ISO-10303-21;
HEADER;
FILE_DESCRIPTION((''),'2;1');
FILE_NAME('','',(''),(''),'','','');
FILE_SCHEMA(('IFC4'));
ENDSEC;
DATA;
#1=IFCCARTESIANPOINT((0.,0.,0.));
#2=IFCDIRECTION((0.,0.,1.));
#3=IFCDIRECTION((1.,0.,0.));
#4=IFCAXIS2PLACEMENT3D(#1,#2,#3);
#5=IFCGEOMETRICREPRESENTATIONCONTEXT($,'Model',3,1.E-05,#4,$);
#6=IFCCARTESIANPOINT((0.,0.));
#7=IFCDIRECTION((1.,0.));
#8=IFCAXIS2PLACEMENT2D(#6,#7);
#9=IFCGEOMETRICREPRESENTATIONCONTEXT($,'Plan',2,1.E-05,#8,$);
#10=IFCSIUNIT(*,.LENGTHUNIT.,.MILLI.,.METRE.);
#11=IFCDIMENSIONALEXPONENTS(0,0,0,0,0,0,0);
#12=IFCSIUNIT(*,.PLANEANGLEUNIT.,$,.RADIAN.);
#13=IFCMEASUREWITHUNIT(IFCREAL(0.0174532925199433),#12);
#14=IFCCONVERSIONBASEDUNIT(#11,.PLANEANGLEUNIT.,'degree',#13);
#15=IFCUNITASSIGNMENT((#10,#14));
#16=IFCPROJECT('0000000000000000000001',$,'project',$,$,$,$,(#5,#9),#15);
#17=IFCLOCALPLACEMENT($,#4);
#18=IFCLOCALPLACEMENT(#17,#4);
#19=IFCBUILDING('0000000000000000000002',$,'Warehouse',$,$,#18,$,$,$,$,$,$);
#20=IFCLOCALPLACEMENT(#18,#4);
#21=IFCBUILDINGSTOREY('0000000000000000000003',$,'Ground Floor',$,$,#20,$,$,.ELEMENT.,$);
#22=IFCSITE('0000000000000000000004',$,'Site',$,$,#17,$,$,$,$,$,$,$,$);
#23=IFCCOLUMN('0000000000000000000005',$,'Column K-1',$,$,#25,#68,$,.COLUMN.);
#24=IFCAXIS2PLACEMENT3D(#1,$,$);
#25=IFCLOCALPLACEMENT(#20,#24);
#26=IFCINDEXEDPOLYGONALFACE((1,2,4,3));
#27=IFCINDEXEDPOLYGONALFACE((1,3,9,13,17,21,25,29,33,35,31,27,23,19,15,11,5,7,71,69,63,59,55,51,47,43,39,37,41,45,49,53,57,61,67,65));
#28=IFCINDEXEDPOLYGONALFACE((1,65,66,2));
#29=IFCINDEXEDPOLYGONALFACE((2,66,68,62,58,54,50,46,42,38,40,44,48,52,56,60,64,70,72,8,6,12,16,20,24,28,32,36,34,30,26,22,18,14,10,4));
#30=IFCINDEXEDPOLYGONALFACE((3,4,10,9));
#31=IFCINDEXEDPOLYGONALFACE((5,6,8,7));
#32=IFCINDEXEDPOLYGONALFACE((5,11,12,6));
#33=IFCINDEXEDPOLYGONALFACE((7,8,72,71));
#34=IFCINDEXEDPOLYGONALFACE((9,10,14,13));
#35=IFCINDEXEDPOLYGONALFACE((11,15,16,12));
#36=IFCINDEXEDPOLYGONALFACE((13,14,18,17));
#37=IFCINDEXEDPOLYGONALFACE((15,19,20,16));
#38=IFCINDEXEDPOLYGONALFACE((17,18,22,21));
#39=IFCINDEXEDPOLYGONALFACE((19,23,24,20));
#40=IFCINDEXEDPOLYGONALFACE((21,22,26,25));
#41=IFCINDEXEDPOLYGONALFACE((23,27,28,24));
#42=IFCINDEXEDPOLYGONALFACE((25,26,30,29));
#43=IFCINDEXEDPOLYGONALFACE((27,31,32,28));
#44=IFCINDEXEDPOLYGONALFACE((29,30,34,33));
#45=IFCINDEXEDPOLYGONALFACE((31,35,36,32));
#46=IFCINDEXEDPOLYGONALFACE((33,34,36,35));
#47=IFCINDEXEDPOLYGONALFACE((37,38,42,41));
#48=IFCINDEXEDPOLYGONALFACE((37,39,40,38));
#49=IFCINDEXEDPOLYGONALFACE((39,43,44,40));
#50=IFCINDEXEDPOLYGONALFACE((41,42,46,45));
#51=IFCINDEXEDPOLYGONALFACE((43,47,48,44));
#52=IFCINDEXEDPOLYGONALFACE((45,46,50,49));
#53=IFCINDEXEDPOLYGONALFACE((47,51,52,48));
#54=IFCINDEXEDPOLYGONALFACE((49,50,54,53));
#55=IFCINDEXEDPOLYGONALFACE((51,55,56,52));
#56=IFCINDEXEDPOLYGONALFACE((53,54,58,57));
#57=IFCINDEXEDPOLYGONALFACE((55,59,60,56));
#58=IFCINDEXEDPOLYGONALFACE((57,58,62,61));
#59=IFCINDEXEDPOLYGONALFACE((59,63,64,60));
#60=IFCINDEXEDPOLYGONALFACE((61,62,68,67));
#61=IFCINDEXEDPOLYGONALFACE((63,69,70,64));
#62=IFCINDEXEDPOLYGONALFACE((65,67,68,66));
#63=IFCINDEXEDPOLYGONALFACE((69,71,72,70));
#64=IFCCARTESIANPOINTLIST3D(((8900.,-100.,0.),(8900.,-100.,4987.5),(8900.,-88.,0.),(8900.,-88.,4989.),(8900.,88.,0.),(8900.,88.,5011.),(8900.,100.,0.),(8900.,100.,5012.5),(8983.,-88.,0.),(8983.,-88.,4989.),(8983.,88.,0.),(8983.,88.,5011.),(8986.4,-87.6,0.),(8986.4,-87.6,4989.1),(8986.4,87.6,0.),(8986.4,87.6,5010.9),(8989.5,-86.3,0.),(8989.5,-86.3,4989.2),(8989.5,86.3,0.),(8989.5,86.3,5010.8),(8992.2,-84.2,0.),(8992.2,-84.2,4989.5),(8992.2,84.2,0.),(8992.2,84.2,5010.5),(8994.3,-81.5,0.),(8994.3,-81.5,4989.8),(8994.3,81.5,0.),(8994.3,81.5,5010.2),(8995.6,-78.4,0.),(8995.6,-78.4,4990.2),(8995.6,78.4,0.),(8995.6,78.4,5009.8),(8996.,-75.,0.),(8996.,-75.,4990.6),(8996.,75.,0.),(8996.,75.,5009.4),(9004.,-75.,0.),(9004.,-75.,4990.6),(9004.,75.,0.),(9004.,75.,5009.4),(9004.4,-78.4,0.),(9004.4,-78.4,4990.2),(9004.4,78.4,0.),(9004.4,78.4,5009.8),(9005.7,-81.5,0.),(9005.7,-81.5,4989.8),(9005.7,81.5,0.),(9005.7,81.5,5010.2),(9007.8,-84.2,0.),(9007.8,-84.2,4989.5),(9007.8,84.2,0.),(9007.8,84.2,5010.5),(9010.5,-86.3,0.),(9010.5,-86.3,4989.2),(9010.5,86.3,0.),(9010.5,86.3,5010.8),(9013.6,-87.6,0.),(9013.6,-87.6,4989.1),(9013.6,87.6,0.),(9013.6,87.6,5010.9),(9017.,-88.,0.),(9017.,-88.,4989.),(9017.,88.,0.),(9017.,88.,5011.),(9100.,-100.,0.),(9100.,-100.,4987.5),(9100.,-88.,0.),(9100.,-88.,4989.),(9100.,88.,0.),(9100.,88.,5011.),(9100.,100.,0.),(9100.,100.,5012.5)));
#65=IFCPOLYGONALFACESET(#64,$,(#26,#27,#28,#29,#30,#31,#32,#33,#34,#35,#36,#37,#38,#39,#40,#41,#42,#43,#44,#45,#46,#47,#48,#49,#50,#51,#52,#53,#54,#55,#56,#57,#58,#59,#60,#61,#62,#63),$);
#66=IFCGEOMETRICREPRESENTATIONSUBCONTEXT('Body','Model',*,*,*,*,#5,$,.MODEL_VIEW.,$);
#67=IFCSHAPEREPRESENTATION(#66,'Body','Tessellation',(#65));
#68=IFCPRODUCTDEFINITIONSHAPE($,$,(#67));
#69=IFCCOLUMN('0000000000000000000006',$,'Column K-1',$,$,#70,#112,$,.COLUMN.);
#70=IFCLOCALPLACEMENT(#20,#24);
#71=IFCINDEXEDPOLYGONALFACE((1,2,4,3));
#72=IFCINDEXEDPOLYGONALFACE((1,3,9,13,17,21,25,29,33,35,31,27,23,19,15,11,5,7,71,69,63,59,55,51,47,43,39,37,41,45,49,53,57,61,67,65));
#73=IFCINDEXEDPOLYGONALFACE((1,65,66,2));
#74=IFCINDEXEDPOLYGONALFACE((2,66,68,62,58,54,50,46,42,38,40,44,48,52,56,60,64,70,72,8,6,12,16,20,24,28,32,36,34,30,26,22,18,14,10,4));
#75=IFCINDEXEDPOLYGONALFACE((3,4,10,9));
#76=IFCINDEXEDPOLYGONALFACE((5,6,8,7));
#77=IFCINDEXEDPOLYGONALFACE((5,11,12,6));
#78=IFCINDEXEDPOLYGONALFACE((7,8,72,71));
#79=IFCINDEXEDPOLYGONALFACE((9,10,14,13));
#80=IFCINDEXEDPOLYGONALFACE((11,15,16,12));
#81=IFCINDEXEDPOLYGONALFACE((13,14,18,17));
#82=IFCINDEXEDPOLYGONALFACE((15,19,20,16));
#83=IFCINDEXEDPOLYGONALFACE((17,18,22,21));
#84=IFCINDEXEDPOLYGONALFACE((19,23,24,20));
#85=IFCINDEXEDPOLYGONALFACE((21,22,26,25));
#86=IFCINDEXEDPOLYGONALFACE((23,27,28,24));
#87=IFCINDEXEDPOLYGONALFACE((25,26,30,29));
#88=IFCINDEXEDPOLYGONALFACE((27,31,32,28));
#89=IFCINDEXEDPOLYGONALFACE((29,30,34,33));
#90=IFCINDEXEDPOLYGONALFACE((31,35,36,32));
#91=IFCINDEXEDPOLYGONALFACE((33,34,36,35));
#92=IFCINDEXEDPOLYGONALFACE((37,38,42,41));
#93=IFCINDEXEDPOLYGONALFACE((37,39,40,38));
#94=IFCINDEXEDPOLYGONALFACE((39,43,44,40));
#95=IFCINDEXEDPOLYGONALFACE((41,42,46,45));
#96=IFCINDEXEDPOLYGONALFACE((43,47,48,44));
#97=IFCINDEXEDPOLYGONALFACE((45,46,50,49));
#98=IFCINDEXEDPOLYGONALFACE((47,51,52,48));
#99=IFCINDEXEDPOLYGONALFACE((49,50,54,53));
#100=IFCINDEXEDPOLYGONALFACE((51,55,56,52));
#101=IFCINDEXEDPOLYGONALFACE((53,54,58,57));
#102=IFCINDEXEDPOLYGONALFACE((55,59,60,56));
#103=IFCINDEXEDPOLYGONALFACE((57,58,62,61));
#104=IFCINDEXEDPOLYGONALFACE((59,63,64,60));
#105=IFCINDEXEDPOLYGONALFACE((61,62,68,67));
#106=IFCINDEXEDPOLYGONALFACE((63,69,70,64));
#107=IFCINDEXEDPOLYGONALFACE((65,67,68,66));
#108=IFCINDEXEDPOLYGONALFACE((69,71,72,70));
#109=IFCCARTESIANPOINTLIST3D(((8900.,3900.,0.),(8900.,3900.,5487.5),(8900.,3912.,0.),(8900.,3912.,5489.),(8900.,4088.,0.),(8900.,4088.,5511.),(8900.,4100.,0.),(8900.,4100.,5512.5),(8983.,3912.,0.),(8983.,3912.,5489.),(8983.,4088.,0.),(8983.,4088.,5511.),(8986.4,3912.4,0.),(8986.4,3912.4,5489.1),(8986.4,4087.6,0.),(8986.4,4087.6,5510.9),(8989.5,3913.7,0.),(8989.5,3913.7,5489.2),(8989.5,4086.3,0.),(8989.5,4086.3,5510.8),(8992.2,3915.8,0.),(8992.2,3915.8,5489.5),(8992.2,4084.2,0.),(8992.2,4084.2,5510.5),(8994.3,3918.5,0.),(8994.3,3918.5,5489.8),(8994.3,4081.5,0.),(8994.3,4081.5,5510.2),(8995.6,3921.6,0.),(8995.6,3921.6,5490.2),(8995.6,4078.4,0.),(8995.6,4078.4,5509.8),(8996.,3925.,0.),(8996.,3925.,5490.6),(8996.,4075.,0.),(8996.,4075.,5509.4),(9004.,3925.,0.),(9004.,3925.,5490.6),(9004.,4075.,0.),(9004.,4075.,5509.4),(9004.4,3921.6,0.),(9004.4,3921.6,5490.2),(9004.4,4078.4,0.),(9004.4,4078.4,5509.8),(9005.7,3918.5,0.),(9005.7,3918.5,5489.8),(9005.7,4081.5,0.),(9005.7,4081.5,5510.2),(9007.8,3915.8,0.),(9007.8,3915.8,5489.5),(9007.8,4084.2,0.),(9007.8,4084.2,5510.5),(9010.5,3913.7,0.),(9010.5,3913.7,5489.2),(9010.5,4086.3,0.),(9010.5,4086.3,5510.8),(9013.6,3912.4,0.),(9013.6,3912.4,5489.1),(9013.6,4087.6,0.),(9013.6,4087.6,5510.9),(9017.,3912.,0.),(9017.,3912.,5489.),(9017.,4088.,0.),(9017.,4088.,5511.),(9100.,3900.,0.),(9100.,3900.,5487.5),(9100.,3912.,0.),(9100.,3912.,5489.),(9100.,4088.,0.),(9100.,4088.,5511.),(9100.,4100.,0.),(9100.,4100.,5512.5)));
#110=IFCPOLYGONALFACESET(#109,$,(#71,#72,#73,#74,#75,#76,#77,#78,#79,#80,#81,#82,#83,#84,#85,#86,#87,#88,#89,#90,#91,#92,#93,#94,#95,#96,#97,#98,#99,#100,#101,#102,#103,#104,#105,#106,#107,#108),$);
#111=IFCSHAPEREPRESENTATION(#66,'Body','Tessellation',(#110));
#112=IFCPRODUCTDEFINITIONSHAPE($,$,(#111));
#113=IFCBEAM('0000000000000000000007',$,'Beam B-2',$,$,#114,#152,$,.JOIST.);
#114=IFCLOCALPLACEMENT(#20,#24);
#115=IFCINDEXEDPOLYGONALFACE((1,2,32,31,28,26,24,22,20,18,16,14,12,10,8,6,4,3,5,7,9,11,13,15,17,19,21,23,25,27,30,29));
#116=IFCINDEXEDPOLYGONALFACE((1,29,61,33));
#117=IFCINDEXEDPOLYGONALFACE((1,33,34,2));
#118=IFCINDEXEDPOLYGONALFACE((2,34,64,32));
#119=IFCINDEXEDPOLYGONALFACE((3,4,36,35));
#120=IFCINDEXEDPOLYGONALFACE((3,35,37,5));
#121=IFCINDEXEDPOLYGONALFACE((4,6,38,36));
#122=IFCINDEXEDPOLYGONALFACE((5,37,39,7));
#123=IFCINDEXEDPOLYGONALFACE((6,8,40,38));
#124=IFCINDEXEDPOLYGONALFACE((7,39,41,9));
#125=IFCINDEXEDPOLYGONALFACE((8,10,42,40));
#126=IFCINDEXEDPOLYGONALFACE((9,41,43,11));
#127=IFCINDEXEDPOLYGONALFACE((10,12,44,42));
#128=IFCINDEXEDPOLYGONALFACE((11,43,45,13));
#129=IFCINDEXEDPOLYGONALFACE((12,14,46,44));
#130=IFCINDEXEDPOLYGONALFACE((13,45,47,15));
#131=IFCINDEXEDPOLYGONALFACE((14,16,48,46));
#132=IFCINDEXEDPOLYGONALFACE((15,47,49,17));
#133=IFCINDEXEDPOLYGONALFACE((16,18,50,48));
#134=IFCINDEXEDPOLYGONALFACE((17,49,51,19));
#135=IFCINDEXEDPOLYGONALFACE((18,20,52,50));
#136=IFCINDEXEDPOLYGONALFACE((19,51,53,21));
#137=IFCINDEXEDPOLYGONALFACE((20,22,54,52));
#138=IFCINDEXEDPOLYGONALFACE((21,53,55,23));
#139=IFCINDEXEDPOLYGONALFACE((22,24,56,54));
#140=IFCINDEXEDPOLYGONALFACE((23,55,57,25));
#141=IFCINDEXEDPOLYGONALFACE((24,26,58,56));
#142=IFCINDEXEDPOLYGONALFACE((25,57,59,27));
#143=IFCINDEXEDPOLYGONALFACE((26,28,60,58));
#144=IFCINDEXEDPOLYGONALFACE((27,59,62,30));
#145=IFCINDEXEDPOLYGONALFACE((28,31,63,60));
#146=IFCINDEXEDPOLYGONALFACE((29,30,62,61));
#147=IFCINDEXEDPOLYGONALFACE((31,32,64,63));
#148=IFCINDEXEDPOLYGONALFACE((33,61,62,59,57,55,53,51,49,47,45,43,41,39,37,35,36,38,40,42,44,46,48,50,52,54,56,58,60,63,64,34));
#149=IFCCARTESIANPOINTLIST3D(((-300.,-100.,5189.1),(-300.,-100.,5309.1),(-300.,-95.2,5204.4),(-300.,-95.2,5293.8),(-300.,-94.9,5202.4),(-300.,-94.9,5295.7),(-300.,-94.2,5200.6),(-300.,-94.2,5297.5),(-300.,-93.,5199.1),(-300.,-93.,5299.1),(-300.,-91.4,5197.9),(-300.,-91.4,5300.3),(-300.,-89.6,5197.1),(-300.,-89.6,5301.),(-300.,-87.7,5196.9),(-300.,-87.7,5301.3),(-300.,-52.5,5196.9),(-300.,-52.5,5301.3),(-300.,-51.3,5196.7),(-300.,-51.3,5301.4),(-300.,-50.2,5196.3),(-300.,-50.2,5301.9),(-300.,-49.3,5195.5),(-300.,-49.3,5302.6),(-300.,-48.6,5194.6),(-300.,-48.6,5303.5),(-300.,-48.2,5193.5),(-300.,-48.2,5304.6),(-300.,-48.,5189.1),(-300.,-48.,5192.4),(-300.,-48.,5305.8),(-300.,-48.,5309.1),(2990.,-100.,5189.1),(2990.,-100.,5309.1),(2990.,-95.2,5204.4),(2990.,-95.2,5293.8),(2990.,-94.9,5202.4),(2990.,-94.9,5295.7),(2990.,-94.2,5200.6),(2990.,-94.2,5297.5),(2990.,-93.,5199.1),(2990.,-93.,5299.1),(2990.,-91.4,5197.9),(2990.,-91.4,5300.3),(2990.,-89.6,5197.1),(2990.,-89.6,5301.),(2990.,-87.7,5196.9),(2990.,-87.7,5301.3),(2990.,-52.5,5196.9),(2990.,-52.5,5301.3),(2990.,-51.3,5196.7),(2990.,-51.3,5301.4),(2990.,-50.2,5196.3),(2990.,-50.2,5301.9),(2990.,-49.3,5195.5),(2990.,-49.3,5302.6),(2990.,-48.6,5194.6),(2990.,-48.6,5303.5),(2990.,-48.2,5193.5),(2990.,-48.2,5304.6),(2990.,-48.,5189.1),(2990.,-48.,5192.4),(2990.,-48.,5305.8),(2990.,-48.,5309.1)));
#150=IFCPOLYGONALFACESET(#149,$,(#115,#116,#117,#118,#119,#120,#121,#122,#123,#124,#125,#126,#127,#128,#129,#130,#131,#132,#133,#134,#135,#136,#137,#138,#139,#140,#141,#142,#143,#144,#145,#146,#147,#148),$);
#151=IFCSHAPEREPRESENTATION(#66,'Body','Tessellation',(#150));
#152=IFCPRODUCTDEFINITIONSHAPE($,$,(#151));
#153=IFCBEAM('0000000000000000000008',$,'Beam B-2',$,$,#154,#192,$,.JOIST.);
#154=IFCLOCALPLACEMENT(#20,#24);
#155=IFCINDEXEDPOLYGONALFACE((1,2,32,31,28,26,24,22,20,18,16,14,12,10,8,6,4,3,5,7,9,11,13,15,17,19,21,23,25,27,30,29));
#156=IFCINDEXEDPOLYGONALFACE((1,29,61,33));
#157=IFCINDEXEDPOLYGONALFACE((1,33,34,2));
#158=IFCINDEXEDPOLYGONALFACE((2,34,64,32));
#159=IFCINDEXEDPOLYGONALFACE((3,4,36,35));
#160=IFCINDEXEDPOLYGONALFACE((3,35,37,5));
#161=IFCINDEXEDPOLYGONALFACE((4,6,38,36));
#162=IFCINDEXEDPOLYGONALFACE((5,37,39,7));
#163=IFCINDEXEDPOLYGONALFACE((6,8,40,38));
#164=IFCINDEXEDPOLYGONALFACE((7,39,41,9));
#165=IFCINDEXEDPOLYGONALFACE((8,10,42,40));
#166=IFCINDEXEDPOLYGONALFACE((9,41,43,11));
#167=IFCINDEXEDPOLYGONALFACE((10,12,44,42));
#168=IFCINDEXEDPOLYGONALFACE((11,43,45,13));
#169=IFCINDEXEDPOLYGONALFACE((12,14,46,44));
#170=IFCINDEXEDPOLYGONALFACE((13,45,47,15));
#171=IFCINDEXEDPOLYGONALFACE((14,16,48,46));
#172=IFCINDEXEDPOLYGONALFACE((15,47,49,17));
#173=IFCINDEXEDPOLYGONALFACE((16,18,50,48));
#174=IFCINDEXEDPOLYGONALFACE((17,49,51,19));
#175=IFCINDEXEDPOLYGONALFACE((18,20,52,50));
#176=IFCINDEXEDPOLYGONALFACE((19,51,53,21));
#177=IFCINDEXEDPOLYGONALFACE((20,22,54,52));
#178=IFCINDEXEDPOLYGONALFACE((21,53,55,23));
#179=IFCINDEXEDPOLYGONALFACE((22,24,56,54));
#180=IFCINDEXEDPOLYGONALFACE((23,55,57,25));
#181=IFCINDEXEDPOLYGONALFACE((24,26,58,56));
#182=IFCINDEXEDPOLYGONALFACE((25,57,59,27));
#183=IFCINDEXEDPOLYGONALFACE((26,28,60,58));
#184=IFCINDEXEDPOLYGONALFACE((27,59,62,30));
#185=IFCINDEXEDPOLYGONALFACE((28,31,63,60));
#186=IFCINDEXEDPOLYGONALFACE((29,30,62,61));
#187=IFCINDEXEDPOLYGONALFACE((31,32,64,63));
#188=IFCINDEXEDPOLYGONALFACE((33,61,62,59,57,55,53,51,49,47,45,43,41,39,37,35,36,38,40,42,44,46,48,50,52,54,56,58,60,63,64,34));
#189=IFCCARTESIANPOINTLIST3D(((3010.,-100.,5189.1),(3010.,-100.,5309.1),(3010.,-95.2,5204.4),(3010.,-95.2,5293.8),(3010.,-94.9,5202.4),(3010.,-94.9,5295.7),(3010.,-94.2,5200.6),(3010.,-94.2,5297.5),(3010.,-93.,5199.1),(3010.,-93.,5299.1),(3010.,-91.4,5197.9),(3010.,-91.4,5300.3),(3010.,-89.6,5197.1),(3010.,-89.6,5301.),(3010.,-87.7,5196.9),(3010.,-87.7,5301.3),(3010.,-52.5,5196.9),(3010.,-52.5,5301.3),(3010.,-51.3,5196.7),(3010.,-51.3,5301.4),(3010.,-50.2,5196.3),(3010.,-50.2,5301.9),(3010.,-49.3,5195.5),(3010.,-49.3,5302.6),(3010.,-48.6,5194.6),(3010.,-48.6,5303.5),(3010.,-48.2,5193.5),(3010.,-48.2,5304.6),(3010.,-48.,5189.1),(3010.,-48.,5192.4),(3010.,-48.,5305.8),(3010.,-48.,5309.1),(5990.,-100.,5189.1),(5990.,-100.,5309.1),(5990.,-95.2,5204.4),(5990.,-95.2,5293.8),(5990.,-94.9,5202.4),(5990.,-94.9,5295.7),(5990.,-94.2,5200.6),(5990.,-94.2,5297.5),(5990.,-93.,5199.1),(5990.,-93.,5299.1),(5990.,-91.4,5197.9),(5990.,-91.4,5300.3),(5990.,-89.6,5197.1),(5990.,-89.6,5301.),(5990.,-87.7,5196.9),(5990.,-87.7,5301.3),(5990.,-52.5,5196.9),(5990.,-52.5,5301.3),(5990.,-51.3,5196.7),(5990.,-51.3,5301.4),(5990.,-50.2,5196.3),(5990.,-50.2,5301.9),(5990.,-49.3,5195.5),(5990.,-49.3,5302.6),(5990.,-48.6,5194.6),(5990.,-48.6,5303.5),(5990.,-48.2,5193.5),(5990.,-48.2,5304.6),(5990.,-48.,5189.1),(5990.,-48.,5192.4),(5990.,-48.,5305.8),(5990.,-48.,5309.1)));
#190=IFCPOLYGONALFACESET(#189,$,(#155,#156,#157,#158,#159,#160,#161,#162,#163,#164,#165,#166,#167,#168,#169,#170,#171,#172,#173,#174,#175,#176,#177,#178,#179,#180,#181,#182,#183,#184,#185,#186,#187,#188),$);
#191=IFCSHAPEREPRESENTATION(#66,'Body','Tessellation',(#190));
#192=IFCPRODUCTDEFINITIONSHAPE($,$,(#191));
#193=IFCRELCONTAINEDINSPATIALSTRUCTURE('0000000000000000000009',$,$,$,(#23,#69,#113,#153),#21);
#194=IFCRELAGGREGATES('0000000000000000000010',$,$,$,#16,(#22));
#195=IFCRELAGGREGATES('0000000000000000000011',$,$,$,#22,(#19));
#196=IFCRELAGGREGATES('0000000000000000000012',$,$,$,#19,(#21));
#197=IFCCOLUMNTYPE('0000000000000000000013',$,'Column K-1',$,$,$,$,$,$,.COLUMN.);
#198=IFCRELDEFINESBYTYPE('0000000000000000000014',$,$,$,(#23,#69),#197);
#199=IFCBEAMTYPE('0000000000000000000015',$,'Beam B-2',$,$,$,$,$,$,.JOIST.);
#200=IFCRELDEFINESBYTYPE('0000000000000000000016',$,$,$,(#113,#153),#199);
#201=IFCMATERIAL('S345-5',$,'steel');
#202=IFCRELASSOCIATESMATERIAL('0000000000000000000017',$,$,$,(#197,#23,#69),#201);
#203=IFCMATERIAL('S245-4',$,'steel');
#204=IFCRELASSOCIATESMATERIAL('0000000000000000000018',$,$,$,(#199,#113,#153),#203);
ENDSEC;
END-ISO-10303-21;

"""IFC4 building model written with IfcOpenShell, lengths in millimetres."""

from ifc_helpers import new_model, entity, si_unit, converted_unit, frame, origin_with_axes, origin_2d_with_axis, place, context, subcontext, project, spatial, i_section, u_section, extrude, clip, halfspace, material, material_profile, profile_set, profile_usage, type_object, element, save


model = new_model("IFC4")

# Units and contexts
model_context = context("Model", 3, precision=1e-05, world=origin_with_axes())
plan_context = context("Plan", 2, precision=1e-05, world=origin_2d_with_axis())
body_context = subcontext(model_context, "Body", "Model", "MODEL_VIEW")
ifc_project = project(units=[si_unit("LENGTHUNIT", "METRE", prefix="MILLI"), converted_unit("PLANEANGLEUNIT", "degree", entity("IfcReal", 0.0174532925199433), si_unit("PLANEANGLEUNIT", "RADIAN"), dimensions=[0, 0, 0, 0, 0, 0, 0])], contexts=[model_context, plan_context])

# Site, building, storey
site_placement = place(None, origin_with_axes())
site = spatial("IfcSite", under=ifc_project, at=site_placement, Name="Site")
building_placement = place(site_placement, origin_with_axes())
building = spatial("IfcBuilding", under=site, at=building_placement, Name="Warehouse")
storey_placement = place(building_placement, origin_with_axes())
storey = spatial("IfcBuildingStorey", under=building, at=storey_placement, Name="Ground Floor", CompositionType="ELEMENT")

# Columns
ifc_material_1 = material(Name="S345-5", Category="steel")
ifc_material_profile_1 = material_profile(ifc_material_1, i_section(OverallWidth=200.0, OverallDepth=200.0, WebThickness=8.0, FlangeThickness=12.0, FilletRadius=13.0, FlangeEdgeRadius=0.0, FlangeSlope=0.0))
ifc_profile_set_1 = profile_set([ifc_material_profile_1], Name="I20K2_S345-5")
column_type = type_object("IfcColumnType", Name="Column K-1", PredefinedType="COLUMN", material=ifc_profile_set_1)
ifc_profile_usage_1 = profile_usage(ifc_profile_set_1, cardinal=5)
column_1_placement = place(storey_placement, frame((9000.0, 0.0, 0.0), z_axis=(0.0, 0.0, 1.0), x_axis=(1.0, 0.0, 0.0)))
element("IfcColumn", 1, at=column_1_placement, inside=storey, type_object=column_type, material=ifc_profile_usage_1, Name="Column K-1", PredefinedType="COLUMN", context=body_context, shape_type="Clipping", body=[
    clip(extrude(i_section(OverallWidth=200.0, OverallDepth=200.0, WebThickness=8.0, FlangeThickness=12.0, FilletRadius=13.0, FlangeEdgeRadius=0.0, FlangeSlope=0.0), origin_with_axes(), (0.0, 0.0, 1.0), 5200.0), halfspace(frame((0.0, -298.5, 4962.7), z_axis=(0.0, -0.124035, 0.992278), x_axis=(0.0, 0.992278, 0.124035)), False)),
])
ifc_profile_usage_2 = profile_usage(ifc_profile_set_1, cardinal=5)
column_2_placement = place(storey_placement, frame((9000.0, 4000.0, 0.0), z_axis=(0.0, 0.0, 1.0), x_axis=(1.0, 0.0, 0.0)))
element("IfcColumn", 2, at=column_2_placement, inside=storey, type_object=column_type, material=ifc_profile_usage_2, Name="Column K-1", PredefinedType="COLUMN", context=body_context, shape_type="Clipping", body=[
    clip(extrude(i_section(OverallWidth=200.0, OverallDepth=200.0, WebThickness=8.0, FlangeThickness=12.0, FilletRadius=13.0, FlangeEdgeRadius=0.0, FlangeSlope=0.0), origin_with_axes(), (0.0, 0.0, 1.0), 5700.0), halfspace(frame((0.0, -4298.5, 4962.7), z_axis=(0.0, -0.124035, 0.992278), x_axis=(0.0, 0.992278, 0.124035)), False)),
])

# Beams
ifc_material_2 = material(Name="S245-4", Category="steel")
ifc_material_profile_2 = material_profile(ifc_material_2, u_section(Depth=120.0, FlangeWidth=52.0, WebThickness=4.8, FlangeThickness=7.8, FilletRadius=7.5, EdgeRadius=4.5, FlangeSlope=0.0))
ifc_profile_set_2 = profile_set([ifc_material_profile_2], Name="U12P_S245-4")
ifc_profile_usage_3 = profile_usage(ifc_profile_set_2, cardinal=3)
beam_type_1 = type_object("IfcBeamType", Name="Beam B-2", PredefinedType="JOIST", material=ifc_profile_set_2)
beam_1_placement = place(storey_placement, frame((-300.0, -100.0, 5189.1), z_axis=(1.0, 0.0, 0.0), x_axis=(0.0, 1.0, 0.0)))
element("IfcBeam", 3, at=beam_1_placement, inside=storey, type_object=beam_type_1, material=ifc_profile_usage_3, Name="Beam B-2", PredefinedType="JOIST", context=body_context, shape_type="SweptSolid", body=[
    extrude(u_section(Depth=120.0, FlangeWidth=52.0, WebThickness=4.8, FlangeThickness=7.8, FilletRadius=7.5, EdgeRadius=4.5, FlangeSlope=0.0), frame((26.0, 60.0, 0.0), z_axis=(0.0, 0.0, 1.0), x_axis=(1.0, 0.0, 0.0)), (0.0, 0.0, 1.0), 3290.0),
])
ifc_profile_usage_4 = profile_usage(ifc_profile_set_2, cardinal=3)
beam_2_placement = place(storey_placement, frame((3010.0, -100.0, 5189.1), z_axis=(1.0, 0.0, 0.0), x_axis=(0.0, 1.0, 0.0)))
element("IfcBeam", 4, at=beam_2_placement, inside=storey, type_object=beam_type_1, material=ifc_profile_usage_4, Name="Beam B-2", PredefinedType="JOIST", context=body_context, shape_type="SweptSolid", body=[
    extrude(u_section(Depth=120.0, FlangeWidth=52.0, WebThickness=4.8, FlangeThickness=7.8, FilletRadius=7.5, EdgeRadius=4.5, FlangeSlope=0.0), frame((26.0, 60.0, 0.0), z_axis=(0.0, 0.0, 1.0), x_axis=(1.0, 0.0, 0.0)), (0.0, 0.0, 1.0), 2980.0),
])

save(model, "model.ifc")
